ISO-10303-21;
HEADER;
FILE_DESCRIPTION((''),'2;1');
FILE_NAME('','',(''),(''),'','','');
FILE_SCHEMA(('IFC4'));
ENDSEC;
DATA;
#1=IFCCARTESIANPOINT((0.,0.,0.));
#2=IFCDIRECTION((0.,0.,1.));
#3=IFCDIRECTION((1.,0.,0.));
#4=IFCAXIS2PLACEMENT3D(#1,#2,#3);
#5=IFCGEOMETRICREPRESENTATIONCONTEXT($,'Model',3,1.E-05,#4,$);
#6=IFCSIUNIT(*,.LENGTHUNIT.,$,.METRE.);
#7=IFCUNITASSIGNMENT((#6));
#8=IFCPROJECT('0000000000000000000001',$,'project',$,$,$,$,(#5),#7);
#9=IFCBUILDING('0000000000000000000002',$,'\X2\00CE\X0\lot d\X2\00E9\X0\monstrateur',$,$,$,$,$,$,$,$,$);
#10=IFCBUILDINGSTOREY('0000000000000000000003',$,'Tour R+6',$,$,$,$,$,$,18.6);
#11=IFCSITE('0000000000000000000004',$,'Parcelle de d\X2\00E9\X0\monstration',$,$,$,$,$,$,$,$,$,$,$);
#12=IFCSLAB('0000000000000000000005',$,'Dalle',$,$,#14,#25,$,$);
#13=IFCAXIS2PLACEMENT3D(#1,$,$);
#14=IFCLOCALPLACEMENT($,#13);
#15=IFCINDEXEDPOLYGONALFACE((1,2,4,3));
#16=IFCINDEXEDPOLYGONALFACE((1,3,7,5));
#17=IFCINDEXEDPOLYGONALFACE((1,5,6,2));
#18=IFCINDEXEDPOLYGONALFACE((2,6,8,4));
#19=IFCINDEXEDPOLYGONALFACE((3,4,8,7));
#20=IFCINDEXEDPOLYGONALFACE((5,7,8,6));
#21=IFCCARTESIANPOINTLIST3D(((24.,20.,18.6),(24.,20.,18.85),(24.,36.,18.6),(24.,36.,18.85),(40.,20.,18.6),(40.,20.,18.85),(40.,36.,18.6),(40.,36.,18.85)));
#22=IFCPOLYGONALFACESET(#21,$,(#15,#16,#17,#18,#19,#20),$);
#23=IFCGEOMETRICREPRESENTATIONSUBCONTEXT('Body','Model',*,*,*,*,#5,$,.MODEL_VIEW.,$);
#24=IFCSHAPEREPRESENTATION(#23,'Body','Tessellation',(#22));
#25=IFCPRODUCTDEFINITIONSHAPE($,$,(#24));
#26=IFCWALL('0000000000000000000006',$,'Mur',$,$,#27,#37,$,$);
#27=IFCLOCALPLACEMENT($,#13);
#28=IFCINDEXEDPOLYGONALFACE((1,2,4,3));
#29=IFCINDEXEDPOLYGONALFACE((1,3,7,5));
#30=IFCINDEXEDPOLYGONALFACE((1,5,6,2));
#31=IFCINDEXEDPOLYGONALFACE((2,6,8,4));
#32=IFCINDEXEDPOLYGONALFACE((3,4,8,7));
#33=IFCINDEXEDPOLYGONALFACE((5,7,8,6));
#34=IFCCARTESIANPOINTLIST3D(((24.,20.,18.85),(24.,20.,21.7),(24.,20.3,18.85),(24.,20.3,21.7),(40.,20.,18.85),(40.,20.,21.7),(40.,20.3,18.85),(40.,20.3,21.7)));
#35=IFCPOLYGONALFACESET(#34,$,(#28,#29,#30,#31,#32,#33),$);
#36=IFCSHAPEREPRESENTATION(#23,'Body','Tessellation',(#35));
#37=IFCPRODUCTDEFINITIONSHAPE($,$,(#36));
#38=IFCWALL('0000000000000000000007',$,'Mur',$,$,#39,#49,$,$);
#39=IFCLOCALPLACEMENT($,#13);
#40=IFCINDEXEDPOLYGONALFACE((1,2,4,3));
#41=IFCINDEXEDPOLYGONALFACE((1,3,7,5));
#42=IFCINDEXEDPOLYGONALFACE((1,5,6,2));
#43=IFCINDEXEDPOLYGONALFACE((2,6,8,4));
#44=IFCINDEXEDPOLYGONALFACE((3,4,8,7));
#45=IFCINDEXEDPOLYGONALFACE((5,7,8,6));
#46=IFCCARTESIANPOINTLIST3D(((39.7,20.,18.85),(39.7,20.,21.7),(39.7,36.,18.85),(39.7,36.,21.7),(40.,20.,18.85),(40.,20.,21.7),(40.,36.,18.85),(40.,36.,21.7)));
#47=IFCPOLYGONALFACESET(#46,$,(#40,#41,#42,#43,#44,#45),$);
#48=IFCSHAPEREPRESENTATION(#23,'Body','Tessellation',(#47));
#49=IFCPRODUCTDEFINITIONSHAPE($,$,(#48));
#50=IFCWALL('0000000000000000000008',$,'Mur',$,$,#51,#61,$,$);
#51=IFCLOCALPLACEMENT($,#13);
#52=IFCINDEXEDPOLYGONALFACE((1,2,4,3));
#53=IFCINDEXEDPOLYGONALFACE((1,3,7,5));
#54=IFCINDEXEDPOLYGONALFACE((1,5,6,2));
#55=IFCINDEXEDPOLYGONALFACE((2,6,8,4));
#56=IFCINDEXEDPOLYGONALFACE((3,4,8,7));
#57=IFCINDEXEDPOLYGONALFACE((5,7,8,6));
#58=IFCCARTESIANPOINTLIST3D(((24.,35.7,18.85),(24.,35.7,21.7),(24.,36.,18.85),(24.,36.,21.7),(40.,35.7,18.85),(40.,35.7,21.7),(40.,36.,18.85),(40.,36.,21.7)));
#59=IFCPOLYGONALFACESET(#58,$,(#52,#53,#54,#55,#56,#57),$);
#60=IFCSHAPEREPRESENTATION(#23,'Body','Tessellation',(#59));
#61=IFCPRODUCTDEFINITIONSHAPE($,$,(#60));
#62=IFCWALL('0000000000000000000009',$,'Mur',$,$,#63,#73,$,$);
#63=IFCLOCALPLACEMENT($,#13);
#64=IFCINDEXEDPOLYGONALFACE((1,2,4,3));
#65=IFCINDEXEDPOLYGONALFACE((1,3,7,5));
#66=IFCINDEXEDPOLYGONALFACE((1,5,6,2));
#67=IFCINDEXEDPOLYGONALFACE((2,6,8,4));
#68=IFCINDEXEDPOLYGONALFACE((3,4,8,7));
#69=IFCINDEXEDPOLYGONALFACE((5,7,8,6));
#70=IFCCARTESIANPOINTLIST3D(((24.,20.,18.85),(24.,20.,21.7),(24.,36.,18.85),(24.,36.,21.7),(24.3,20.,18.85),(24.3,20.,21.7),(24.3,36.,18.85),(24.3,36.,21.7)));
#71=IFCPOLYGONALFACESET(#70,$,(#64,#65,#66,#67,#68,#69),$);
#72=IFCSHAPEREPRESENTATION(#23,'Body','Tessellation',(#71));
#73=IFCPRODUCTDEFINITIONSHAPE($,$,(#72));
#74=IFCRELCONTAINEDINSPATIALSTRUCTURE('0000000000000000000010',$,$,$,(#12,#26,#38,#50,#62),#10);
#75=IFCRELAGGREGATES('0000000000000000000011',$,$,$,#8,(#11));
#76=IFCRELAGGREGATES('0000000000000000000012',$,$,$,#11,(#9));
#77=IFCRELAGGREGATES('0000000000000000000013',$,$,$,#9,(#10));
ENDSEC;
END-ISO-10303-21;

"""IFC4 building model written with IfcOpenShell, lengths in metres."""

from ifc_helpers import new_model, si_unit, frame, origin_with_axes, place, context, subcontext, project, spatial, indexed_curve, outline, extrude, element, save


model = new_model("IFC4")

# Units and contexts
model_context = context("Model", 3, precision=1e-05, world=origin_with_axes())
body_context = subcontext(model_context, "Body", "Model", "MODEL_VIEW")
ifc_project = project(units=[si_unit("LENGTHUNIT", "METRE")], contexts=[model_context])

# Site, building, storey
site = spatial("IfcSite", under=ifc_project, Name="Parcelle de démonstration")
building = spatial("IfcBuilding", under=site, Name="Îlot démonstrateur")
storey = spatial("IfcBuildingStorey", under=building, Name="Tour R+6", Elevation=18.6)

# Slab
slab_placement = place(None, frame((0.0, 0.0, 18.6), z_axis=(0.0, 0.0, 1.0), x_axis=(1.0, 0.0, 0.0)))
element("IfcSlab", 1, at=slab_placement, inside=storey, Name="Dalle", context=body_context, shape_type="SweptSolid", body=[
    extrude(outline(indexed_curve([(24.0, 20.0), (40.0, 20.0), (40.0, 36.0), (24.0, 36.0)])), None, (0.0, 0.0, 1.0), 0.25),
])

# Walls
for number, where, z_axis, x_axis, name in (
    (2, (24.0, 20.0, 18.85), (0.0, 0.0, 1.0), (1.0, 0.0, 0.0), "Mur"),
    (3, (40.0, 20.0, 18.85), (0.0, 0.0, 1.0), (0.0, 1.0, 0.0), "Mur"),
    (4, (40.0, 36.0, 18.85), (0.0, 0.0, 1.0), (-1.0, 0.0, 0.0), "Mur"),
    (5, (24.0, 36.0, 18.85), (0.0, 0.0, 1.0), (0.0, -1.0, 0.0), "Mur"),
):
    element("IfcWall", number, at=place(None, frame(where, z_axis=z_axis, x_axis=x_axis)), inside=storey, Name=name, context=body_context, shape_type="SweptSolid", body=[
        extrude(outline(indexed_curve([(0.0, 0.0), (0.0, 0.3), (16.0, 0.3), (16.0, 0.0), (0.0, 0.0)], self_intersect=False)), origin_with_axes(), (0.0, 0.0, 1.0), 2.85),
    ])

save(model, "model.ifc")
